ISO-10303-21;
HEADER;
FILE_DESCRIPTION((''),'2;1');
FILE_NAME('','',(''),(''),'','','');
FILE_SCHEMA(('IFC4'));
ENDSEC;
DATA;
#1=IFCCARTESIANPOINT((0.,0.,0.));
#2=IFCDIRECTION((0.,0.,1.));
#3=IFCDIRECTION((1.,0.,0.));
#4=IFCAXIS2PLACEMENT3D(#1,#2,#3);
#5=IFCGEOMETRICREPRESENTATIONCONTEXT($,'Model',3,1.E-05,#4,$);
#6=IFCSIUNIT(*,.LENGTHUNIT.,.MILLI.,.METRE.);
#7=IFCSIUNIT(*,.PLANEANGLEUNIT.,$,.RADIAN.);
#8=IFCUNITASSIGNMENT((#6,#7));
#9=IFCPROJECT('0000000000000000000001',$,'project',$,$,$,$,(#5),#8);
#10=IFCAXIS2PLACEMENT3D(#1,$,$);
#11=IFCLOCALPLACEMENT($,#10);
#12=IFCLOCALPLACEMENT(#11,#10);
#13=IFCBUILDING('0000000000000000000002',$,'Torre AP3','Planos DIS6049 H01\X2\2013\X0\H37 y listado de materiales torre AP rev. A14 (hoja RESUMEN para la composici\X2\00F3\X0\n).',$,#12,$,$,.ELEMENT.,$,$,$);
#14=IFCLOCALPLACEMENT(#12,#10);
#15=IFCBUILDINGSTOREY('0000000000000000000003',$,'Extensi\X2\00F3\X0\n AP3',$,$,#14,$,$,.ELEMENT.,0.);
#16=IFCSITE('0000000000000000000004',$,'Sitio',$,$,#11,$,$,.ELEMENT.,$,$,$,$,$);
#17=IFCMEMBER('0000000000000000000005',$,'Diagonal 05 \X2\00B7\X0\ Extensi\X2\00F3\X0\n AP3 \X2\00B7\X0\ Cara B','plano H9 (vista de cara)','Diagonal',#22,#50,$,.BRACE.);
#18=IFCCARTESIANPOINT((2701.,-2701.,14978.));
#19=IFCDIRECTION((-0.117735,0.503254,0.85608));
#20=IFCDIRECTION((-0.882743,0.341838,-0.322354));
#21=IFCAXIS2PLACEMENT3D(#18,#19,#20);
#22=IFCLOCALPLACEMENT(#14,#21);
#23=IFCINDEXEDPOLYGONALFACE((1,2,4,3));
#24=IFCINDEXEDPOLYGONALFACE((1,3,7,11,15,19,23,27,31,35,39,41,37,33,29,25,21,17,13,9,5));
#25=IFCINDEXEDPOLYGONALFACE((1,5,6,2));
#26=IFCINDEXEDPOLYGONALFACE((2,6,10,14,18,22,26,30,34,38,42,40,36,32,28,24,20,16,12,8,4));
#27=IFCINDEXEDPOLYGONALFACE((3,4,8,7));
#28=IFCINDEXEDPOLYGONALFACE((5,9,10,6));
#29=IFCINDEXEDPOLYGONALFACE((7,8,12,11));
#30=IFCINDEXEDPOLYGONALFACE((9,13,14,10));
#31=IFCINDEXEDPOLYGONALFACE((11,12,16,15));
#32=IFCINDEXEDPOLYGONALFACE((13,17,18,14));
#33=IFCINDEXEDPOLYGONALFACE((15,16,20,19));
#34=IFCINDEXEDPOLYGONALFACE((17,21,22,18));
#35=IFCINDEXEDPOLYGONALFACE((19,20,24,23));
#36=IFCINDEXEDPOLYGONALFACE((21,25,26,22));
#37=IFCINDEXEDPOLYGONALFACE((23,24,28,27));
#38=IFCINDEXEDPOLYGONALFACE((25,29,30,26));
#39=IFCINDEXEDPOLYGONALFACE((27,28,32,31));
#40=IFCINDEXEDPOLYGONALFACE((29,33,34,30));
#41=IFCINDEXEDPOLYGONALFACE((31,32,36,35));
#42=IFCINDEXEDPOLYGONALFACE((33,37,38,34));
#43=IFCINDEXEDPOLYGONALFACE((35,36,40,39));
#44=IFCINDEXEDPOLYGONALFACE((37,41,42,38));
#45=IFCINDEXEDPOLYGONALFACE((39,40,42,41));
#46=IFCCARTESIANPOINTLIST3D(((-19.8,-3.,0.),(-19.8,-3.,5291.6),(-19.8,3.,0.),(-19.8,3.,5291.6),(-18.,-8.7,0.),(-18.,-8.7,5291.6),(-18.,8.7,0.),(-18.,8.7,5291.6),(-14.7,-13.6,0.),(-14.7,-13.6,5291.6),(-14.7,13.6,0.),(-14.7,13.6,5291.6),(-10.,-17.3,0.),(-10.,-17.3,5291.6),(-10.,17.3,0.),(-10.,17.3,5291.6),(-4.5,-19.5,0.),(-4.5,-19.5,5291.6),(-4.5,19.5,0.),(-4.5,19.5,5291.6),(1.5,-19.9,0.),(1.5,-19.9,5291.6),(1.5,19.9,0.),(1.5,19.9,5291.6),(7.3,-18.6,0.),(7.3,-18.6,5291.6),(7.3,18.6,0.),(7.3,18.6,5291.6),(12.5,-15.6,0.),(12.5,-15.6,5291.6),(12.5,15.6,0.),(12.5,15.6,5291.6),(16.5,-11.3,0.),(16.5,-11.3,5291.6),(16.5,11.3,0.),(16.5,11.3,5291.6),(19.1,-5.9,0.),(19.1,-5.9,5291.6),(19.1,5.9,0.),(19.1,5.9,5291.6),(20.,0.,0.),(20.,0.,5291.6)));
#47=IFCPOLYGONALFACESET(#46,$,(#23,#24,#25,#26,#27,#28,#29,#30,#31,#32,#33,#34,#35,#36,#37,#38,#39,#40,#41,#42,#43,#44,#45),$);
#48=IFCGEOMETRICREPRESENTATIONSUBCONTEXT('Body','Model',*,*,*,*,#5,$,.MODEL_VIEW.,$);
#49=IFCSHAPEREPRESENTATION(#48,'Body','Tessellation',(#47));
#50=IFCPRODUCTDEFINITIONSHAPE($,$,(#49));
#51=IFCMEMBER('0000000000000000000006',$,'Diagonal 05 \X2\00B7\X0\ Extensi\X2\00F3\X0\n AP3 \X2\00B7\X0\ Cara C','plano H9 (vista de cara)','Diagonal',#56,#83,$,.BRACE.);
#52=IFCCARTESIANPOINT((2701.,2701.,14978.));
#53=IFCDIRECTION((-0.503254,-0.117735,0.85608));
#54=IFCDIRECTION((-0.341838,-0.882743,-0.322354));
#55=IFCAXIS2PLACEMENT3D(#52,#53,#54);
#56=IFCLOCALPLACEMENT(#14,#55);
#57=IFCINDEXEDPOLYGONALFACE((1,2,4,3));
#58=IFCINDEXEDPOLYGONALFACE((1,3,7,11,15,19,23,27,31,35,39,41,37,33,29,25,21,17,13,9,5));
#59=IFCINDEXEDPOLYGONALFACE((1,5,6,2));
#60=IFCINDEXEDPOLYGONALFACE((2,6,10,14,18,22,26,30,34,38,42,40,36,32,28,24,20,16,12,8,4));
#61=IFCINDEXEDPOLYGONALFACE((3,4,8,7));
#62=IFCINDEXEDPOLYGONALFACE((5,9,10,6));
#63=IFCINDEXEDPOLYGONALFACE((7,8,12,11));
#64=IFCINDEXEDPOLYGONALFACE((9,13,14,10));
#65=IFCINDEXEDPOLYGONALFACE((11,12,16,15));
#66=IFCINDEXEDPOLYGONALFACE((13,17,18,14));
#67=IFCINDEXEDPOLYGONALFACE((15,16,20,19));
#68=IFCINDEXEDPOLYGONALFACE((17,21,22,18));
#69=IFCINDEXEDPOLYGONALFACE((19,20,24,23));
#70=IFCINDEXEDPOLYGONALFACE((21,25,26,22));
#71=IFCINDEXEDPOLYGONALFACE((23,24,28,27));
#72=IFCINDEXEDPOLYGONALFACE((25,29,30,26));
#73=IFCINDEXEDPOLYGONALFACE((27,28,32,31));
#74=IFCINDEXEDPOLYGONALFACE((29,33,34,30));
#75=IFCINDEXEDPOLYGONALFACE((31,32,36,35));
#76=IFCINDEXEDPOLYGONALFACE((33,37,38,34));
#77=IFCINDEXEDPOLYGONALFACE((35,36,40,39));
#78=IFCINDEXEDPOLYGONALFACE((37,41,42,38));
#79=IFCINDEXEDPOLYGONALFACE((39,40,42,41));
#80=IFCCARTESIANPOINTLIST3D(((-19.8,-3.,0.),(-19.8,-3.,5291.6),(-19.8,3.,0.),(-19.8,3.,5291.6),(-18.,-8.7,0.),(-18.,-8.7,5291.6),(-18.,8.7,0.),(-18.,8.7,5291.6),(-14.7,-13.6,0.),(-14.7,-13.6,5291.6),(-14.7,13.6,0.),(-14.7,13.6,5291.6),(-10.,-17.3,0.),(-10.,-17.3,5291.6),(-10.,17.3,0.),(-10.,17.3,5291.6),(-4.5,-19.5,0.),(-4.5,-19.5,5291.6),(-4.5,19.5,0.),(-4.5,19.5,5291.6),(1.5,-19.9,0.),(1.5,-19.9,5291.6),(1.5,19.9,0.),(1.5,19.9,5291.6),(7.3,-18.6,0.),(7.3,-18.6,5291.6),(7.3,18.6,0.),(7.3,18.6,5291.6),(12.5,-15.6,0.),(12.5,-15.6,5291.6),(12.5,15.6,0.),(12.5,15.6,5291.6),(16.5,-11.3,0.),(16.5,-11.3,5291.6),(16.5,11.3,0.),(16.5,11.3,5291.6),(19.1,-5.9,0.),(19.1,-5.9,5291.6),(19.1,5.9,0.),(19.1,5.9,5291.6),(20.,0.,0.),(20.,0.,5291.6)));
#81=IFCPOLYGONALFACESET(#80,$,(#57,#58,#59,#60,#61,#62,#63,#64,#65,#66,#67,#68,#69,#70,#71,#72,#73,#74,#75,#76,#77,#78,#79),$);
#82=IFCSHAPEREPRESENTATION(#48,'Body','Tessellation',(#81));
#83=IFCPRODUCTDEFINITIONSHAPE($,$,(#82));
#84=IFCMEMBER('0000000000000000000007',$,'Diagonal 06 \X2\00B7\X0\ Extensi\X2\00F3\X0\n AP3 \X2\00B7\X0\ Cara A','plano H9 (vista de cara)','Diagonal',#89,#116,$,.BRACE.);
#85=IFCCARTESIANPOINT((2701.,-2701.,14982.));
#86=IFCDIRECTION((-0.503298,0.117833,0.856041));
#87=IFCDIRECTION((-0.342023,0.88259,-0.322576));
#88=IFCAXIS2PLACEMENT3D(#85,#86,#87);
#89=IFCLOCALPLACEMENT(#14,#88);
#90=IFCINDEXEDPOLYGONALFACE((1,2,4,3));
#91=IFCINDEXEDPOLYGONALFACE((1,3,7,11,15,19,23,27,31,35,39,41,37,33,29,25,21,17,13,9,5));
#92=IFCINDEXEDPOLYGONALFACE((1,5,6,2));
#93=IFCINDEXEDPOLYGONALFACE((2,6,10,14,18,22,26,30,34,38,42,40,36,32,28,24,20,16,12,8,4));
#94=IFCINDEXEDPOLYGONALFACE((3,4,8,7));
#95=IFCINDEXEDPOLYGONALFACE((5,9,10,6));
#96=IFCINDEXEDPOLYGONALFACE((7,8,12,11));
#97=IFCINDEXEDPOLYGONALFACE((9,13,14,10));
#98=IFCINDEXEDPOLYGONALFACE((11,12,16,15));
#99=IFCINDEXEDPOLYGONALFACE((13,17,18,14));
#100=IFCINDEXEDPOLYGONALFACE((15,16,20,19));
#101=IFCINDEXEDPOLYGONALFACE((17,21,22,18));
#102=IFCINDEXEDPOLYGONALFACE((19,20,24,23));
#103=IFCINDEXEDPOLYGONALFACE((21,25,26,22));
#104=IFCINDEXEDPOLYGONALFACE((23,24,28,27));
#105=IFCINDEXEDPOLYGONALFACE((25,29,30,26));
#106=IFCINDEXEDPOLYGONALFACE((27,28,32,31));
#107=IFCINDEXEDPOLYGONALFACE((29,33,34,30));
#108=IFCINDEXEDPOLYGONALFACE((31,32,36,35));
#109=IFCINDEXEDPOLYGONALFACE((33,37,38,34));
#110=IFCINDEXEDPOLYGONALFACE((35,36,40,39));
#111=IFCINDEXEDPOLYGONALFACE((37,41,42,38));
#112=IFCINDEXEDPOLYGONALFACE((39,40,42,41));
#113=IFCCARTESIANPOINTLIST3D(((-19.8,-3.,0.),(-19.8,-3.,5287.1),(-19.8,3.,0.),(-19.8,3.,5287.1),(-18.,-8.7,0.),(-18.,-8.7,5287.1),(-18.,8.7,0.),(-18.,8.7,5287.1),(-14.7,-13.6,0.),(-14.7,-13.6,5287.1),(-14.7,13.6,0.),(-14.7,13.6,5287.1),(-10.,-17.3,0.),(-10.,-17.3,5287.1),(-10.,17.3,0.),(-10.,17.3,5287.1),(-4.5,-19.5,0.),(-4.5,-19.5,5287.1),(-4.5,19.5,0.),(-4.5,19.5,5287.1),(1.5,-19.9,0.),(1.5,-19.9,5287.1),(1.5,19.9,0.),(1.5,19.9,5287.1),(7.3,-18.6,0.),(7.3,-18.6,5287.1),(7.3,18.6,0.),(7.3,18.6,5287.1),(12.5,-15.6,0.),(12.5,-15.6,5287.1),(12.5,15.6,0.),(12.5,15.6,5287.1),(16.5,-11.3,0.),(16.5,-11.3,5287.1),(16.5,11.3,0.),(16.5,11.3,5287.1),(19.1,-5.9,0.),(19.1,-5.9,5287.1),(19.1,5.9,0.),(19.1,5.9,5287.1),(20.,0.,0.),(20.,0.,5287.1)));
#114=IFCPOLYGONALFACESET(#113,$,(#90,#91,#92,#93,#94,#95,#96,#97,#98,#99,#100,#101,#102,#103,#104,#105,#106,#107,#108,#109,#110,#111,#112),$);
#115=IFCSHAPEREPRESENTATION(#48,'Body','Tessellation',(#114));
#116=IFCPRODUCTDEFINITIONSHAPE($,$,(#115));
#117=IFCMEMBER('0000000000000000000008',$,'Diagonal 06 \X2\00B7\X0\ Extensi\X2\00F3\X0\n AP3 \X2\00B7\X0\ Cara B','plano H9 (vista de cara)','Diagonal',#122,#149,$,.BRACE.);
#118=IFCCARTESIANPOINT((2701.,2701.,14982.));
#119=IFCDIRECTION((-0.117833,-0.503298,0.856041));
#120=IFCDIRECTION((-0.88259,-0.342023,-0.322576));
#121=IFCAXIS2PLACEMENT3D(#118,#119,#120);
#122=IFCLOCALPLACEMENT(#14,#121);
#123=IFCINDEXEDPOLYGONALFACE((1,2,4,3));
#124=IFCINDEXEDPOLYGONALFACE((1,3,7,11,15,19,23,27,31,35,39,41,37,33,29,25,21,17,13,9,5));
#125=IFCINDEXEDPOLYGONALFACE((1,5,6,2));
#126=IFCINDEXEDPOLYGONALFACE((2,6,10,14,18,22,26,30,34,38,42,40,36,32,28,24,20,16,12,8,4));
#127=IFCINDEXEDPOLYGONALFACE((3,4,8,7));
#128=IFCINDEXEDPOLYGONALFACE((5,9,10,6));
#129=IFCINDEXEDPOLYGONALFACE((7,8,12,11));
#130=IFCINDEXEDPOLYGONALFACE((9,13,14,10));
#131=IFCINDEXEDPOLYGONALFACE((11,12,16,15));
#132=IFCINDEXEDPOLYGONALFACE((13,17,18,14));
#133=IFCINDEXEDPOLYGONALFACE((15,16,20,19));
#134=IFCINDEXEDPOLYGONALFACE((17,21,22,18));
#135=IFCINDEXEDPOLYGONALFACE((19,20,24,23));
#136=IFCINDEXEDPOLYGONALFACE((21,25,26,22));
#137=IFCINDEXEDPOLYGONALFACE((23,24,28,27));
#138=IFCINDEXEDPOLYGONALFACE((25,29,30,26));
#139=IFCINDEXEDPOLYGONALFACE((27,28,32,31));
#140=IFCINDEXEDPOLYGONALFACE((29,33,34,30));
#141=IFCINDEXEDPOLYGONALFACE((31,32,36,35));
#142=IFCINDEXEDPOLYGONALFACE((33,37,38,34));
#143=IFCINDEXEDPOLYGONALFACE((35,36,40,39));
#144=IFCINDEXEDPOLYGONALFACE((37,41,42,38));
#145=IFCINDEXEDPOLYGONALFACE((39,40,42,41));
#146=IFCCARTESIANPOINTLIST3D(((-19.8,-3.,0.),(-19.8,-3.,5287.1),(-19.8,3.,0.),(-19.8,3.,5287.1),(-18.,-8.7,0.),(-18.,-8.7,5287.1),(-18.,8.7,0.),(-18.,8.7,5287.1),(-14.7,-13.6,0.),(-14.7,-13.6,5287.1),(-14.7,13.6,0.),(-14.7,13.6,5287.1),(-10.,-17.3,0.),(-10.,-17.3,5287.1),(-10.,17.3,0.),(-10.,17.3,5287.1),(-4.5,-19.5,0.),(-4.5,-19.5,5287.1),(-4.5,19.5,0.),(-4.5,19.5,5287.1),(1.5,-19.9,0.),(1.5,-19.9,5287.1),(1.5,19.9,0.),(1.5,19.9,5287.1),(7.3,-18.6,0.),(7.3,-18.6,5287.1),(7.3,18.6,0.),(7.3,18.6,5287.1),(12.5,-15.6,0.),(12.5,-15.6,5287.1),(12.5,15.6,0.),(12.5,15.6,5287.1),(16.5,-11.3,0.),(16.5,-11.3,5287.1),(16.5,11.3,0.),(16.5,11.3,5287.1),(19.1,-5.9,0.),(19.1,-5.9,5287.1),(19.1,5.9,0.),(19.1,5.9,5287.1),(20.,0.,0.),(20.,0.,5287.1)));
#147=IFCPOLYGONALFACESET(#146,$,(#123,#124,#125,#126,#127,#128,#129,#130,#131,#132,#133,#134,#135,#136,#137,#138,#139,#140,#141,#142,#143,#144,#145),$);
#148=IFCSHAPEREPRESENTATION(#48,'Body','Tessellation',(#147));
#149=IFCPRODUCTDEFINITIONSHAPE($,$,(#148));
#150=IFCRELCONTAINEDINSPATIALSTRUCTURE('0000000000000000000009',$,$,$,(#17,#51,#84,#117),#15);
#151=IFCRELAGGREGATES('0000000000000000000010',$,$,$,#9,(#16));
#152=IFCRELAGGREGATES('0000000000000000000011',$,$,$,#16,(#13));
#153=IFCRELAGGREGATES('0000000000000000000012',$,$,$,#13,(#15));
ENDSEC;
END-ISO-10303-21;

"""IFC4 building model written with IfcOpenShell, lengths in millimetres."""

from ifc_helpers import new_model, si_unit, frame, origin, origin_with_axes, place, context, subcontext, project, spatial, circle, extrude, element, save


model = new_model("IFC4")

# Units and contexts
model_context = context("Model", 3, precision=1e-05, world=origin_with_axes())
body_context = subcontext(model_context, "Body", "Model", "MODEL_VIEW")
ifc_project = project(units=[si_unit("LENGTHUNIT", "METRE", prefix="MILLI"), si_unit("PLANEANGLEUNIT", "RADIAN")], contexts=[model_context])

# Site, building, storey
site_placement = place(None, origin())
site = spatial("IfcSite", under=ifc_project, at=site_placement, Name="Sitio", CompositionType="ELEMENT")
building_placement = place(site_placement, origin())
building = spatial("IfcBuilding", under=site, at=building_placement, Name="Torre AP3", Description="Planos DIS6049 H01–H37 y listado de materiales torre AP rev. A14 (hoja RESUMEN para la composición).", CompositionType="ELEMENT")
storey_placement = place(building_placement, origin())
storey = spatial("IfcBuildingStorey", under=building, at=storey_placement, Name="Extensión AP3", CompositionType="ELEMENT", Elevation=0.0)

# Members
for number, where, z_axis, x_axis, name in (
    (1, (2701.0, -2701.0, 14978.0), (-0.117735, 0.503254, 0.85608), (-0.882743, 0.341838, -0.322354), "Diagonal 05 · Extensión AP3 · Cara B"),
    (2, (2701.0, 2701.0, 14978.0), (-0.503254, -0.117735, 0.85608), (-0.341838, -0.882743, -0.322354), "Diagonal 05 · Extensión AP3 · Cara C"),
):
    element("IfcMember", number, at=place(storey_placement, frame(where, z_axis=z_axis, x_axis=x_axis)), inside=storey, Name=name, Description="plano H9 (vista de cara)", ObjectType="Diagonal", PredefinedType="BRACE", context=body_context, shape_type="SweptSolid", body=[
        extrude(circle(Radius=20.0), None, (0.0, 0.0, 1.0), 5291.6),
    ])
for number, where, z_axis, x_axis, name in (
    (3, (2701.0, -2701.0, 14982.0), (-0.503298, 0.117833, 0.856041), (-0.342023, 0.88259, -0.322576), "Diagonal 06 · Extensión AP3 · Cara A"),
    (4, (2701.0, 2701.0, 14982.0), (-0.117833, -0.503298, 0.856041), (-0.88259, -0.342023, -0.322576), "Diagonal 06 · Extensión AP3 · Cara B"),
):
    element("IfcMember", number, at=place(storey_placement, frame(where, z_axis=z_axis, x_axis=x_axis)), inside=storey, Name=name, Description="plano H9 (vista de cara)", ObjectType="Diagonal", PredefinedType="BRACE", context=body_context, shape_type="SweptSolid", body=[
        extrude(circle(Radius=20.0), None, (0.0, 0.0, 1.0), 5287.1),
    ])

save(model, "model.ifc")
